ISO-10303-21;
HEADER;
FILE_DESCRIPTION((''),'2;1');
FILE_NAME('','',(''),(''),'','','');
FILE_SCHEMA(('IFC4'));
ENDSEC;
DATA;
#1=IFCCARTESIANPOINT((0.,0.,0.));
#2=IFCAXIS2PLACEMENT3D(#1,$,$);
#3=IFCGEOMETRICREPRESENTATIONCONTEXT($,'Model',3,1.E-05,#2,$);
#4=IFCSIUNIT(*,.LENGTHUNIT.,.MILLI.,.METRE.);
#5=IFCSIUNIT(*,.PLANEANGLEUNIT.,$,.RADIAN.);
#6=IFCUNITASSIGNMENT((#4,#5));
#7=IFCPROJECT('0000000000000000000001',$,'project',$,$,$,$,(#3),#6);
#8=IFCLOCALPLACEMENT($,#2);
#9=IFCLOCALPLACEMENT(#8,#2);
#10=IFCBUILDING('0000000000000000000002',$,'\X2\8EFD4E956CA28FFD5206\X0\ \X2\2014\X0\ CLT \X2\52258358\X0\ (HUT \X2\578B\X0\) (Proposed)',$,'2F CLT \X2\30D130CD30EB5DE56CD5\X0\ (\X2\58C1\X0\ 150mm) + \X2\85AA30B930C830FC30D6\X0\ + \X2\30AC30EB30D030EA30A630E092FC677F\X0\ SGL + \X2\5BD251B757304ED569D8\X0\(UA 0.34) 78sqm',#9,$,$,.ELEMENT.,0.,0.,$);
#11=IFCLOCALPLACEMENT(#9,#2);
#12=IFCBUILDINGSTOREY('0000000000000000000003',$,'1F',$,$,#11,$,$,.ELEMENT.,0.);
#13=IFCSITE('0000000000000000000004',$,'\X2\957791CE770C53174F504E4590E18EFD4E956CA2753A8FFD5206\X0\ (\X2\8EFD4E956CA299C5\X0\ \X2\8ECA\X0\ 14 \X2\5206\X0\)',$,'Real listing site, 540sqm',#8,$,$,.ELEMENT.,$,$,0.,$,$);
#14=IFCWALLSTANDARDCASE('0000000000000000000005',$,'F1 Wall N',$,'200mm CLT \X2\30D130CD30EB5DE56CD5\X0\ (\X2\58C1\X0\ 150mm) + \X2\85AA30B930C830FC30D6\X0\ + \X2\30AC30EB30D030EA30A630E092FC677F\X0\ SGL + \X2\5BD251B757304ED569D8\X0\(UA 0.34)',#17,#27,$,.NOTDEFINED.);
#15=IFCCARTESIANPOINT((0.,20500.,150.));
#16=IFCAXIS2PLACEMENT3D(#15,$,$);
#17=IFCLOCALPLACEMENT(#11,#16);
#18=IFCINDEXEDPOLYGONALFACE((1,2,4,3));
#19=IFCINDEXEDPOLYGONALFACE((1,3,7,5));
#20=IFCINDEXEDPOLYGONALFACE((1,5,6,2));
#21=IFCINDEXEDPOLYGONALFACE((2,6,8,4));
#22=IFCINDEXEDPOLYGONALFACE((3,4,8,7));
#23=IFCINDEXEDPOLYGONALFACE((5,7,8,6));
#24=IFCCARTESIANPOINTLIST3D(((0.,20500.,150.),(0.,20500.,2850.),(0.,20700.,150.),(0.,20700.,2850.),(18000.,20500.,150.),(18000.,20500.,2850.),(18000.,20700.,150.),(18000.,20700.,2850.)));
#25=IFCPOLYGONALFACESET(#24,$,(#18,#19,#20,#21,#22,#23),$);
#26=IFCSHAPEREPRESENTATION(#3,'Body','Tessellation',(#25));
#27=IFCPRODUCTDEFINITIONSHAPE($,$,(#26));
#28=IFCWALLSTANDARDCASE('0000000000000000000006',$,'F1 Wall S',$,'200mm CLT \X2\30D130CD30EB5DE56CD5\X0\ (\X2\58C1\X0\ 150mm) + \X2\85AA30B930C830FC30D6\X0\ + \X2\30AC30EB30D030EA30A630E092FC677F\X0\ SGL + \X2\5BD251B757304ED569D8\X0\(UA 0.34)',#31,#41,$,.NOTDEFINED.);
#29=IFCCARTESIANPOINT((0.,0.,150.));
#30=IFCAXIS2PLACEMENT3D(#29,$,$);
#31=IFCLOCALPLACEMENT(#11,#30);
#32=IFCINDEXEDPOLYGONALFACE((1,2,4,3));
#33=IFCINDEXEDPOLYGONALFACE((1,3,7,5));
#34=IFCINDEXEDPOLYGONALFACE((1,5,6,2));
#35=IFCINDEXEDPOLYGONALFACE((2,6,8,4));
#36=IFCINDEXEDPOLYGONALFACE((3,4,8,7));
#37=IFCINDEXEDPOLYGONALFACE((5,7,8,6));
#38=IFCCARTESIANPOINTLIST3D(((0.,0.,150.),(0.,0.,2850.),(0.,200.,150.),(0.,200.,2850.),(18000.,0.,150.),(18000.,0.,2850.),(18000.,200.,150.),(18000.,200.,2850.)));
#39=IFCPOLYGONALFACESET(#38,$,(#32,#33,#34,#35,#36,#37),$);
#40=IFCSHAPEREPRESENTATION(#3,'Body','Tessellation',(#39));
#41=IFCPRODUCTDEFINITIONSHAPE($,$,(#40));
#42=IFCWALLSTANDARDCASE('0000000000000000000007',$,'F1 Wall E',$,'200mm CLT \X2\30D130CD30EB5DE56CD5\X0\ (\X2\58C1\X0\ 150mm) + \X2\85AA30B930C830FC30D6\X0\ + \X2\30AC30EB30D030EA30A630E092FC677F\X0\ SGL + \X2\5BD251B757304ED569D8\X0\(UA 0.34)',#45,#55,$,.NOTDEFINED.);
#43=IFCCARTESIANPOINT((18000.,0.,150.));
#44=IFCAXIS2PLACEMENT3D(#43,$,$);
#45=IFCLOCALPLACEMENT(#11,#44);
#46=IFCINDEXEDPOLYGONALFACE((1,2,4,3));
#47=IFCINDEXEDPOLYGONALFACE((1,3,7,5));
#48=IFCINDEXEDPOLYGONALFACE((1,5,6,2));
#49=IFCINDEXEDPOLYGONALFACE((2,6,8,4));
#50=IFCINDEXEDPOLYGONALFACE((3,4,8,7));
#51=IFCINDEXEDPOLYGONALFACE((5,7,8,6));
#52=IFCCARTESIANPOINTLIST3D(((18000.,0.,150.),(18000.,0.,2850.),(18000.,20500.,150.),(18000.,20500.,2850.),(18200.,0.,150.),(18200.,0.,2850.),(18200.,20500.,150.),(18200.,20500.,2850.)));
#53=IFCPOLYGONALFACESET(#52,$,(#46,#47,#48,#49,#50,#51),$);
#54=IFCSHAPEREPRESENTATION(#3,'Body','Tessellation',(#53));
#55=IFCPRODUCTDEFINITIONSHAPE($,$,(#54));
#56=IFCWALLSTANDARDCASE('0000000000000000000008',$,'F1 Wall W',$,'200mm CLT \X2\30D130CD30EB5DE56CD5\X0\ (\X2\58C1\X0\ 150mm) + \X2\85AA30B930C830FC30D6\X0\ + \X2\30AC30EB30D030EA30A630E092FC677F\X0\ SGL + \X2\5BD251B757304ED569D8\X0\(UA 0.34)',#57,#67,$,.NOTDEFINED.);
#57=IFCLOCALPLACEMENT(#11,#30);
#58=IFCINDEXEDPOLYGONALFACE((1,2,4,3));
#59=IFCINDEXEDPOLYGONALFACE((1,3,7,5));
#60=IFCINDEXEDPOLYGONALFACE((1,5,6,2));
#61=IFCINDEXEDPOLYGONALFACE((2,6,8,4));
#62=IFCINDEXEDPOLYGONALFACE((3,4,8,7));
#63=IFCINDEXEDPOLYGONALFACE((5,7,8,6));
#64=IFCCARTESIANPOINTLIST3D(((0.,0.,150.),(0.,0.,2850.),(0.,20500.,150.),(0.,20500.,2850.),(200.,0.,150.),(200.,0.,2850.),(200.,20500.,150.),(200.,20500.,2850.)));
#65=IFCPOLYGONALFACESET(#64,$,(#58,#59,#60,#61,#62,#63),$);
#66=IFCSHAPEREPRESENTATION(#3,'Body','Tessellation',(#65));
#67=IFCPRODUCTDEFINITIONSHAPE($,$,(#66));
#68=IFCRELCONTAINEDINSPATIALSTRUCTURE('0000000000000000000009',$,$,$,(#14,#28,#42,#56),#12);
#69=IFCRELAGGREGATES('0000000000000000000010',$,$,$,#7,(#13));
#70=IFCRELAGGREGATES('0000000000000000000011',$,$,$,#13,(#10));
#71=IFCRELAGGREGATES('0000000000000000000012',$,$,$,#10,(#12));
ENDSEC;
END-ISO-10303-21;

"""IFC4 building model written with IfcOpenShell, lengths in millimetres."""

from ifc_helpers import new_model, si_unit, frame, frame_2d, origin, place, context, project, spatial, rectangle, extrude, element, save


model = new_model("IFC4")

# Units and contexts
model_context = context("Model", 3, precision=1e-05, world=origin())
ifc_project = project(units=[si_unit("LENGTHUNIT", "METRE", prefix="MILLI"), si_unit("PLANEANGLEUNIT", "RADIAN")], contexts=[model_context])

# Site, building, storey
site_placement = place(None, origin())
site = spatial("IfcSite", under=ifc_project, at=site_placement, Name="長野県北佐久郡軽井沢町追分 (軽井沢駅 車 14 分)", ObjectType="Real listing site, 540sqm", CompositionType="ELEMENT", RefElevation=0.0)
building_placement = place(site_placement, origin())
building = spatial("IfcBuilding", under=site, at=building_placement, Name="軽井沢追分 — CLT 別荘 (HUT 型) (Proposed)", ObjectType="2F CLT パネル工法 (壁 150mm) + 薪ストーブ + ガルバリウム鋼板 SGL + 寒冷地仕様(UA 0.34) 78sqm", CompositionType="ELEMENT", ElevationOfRefHeight=0.0, ElevationOfTerrain=0.0)
storey_placement = place(building_placement, origin())
storey = spatial("IfcBuildingStorey", under=building, at=storey_placement, Name="1F", CompositionType="ELEMENT", Elevation=0.0)

# Walls
wall_1_placement = place(storey_placement, frame((0.0, 20500.0, 150.0)))
element("IfcWallStandardCase", 1, at=wall_1_placement, inside=storey, Name="F1 Wall N", ObjectType="200mm CLT パネル工法 (壁 150mm) + 薪ストーブ + ガルバリウム鋼板 SGL + 寒冷地仕様(UA 0.34)", PredefinedType="NOTDEFINED", context=model_context, shape_type="SweptSolid", body=[
    extrude(rectangle(XDim=18000.0, YDim=200.0, at=frame_2d((9000.0, 100.0))), frame((0.0, 20500.0, 150.0)), (0.0, 0.0, 1.0), 2700.0),
])
wall_2_placement = place(storey_placement, frame((0.0, 0.0, 150.0)))
element("IfcWallStandardCase", 2, at=wall_2_placement, inside=storey, Name="F1 Wall S", ObjectType="200mm CLT パネル工法 (壁 150mm) + 薪ストーブ + ガルバリウム鋼板 SGL + 寒冷地仕様(UA 0.34)", PredefinedType="NOTDEFINED", context=model_context, shape_type="SweptSolid", body=[
    extrude(rectangle(XDim=18000.0, YDim=200.0, at=frame_2d((9000.0, 100.0))), frame((0.0, 0.0, 150.0)), (0.0, 0.0, 1.0), 2700.0),
])
wall_3_placement = place(storey_placement, frame((18000.0, 0.0, 150.0)))
element("IfcWallStandardCase", 3, at=wall_3_placement, inside=storey, Name="F1 Wall E", ObjectType="200mm CLT パネル工法 (壁 150mm) + 薪ストーブ + ガルバリウム鋼板 SGL + 寒冷地仕様(UA 0.34)", PredefinedType="NOTDEFINED", context=model_context, shape_type="SweptSolid", body=[
    extrude(rectangle(XDim=200.0, YDim=20500.0, at=frame_2d((100.0, 10250.0))), frame((18000.0, 0.0, 150.0)), (0.0, 0.0, 1.0), 2700.0),
])
wall_4_placement = place(storey_placement, frame((0.0, 0.0, 150.0)))
element("IfcWallStandardCase", 4, at=wall_4_placement, inside=storey, Name="F1 Wall W", ObjectType="200mm CLT パネル工法 (壁 150mm) + 薪ストーブ + ガルバリウム鋼板 SGL + 寒冷地仕様(UA 0.34)", PredefinedType="NOTDEFINED", context=model_context, shape_type="SweptSolid", body=[
    extrude(rectangle(XDim=200.0, YDim=20500.0, at=frame_2d((100.0, 10250.0))), frame((0.0, 0.0, 150.0)), (0.0, 0.0, 1.0), 2700.0),
])

save(model, "model.ifc")
